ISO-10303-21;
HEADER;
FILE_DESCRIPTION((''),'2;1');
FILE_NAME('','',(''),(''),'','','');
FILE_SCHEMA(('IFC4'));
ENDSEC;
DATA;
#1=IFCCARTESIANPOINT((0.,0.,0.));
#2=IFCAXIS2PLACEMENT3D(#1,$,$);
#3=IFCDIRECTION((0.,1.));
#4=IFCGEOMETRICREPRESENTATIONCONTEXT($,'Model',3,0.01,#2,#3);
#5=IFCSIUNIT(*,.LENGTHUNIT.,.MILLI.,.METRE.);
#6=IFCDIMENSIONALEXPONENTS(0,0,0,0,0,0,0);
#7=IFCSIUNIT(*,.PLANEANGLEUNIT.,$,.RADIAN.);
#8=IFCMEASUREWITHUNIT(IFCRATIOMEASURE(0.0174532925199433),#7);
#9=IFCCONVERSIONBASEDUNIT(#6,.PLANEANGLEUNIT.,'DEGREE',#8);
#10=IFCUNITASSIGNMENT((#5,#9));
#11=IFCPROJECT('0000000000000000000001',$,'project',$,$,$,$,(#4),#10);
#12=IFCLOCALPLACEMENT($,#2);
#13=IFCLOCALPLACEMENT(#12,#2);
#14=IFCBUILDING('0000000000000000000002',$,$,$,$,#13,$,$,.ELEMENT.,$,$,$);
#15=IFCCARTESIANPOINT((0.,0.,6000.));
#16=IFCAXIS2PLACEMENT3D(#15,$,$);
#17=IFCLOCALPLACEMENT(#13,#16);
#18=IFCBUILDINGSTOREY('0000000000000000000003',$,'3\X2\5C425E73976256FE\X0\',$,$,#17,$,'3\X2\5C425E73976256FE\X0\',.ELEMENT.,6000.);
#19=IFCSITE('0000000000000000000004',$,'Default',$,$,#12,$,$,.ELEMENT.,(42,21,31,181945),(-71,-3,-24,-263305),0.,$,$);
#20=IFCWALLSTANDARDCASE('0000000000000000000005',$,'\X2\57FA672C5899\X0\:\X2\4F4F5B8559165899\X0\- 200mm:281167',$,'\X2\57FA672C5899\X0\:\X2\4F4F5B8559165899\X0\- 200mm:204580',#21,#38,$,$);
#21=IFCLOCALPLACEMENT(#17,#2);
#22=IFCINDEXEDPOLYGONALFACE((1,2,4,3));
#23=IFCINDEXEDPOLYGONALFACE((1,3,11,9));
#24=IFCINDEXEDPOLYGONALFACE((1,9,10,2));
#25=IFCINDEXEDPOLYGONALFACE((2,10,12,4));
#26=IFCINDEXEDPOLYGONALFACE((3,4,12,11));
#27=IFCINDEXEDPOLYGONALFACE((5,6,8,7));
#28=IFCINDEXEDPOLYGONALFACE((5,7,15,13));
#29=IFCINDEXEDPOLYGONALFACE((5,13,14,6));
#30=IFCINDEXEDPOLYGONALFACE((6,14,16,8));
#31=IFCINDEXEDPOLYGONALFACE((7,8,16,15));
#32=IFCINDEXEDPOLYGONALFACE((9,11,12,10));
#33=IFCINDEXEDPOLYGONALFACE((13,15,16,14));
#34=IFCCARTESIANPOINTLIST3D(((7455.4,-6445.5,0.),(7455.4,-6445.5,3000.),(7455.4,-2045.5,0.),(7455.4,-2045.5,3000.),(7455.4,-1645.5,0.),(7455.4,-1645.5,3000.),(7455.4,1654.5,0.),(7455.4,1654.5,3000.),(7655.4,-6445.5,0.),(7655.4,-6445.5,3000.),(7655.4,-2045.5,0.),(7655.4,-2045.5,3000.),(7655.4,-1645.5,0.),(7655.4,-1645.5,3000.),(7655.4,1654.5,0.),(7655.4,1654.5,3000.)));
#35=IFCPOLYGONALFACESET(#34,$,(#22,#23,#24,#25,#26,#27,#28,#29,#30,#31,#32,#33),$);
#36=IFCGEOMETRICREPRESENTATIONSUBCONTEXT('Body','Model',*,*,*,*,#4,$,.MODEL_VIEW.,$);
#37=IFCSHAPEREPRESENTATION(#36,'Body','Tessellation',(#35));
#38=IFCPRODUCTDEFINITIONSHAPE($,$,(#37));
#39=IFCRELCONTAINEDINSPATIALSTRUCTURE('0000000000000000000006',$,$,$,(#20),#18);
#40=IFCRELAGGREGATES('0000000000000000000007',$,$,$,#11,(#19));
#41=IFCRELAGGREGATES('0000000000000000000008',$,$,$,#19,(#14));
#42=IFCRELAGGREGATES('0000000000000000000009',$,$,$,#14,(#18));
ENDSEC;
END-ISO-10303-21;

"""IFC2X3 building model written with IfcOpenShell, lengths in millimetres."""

from ifc_helpers import new_model, entity, si_unit, converted_unit, direction, frame, frame_2d, origin, origin_2d_with_axis, place, context, subcontext, project, spatial, polyline, rectangle, extrude, clip, bounded_halfspace, element, save


model = new_model("IFC2X3")

# Units and contexts
model_context = context("Model", 3, precision=0.01, world=origin(), true_north=direction((0.0, 1.0)))
body_context = subcontext(model_context, "Body", "Model", "MODEL_VIEW")
ifc_project = project(units=[si_unit("LENGTHUNIT", "METRE", prefix="MILLI"), converted_unit("PLANEANGLEUNIT", "DEGREE", entity("IfcRatioMeasure", 0.0174532925199433), si_unit("PLANEANGLEUNIT", "RADIAN"), dimensions=[0, 0, 0, 0, 0, 0, 0])], contexts=[model_context])

# Site, building, storey
site_placement = place(None, origin())
site = spatial("IfcSite", under=ifc_project, at=site_placement, Name="Default", CompositionType="ELEMENT", RefLatitude=(42, 21, 31, 181945), RefLongitude=(-71, -3, -24, -263305), RefElevation=0.0)
building_placement = place(site_placement, origin())
building = spatial("IfcBuilding", under=site, at=building_placement, CompositionType="ELEMENT")
storey_placement = place(building_placement, frame((0.0, 0.0, 6000.0)))
storey = spatial("IfcBuildingStorey", under=building, at=storey_placement, Name="3层平面图", LongName="3层平面图", CompositionType="ELEMENT", Elevation=6000.0)

# Wall, opening
wall_placement = place(storey_placement, frame((7555.4, 1654.5, 0.0), z_axis=(0.0, 0.0, 1.0), x_axis=(0.0, -1.0, 0.0)))
wall = element("IfcWallStandardCase", 1, at=wall_placement, inside=storey, Name="基本墙:住宅外墙- 200mm:281167", ObjectType="基本墙:住宅外墙- 200mm:204580", context=body_context, shape_type="Clipping", body=[
    clip(extrude(rectangle(XDim=8100.0, YDim=200.0, at=frame_2d((4050.0, 0.0), x_axis=(-1.0, 0.0))), origin(), (0.0, 0.0, 1.0), 3000.0), bounded_halfspace(frame((8100.0, -100.0, 3000.0), z_axis=(1.0, 0.0, 0.0), x_axis=(0.0, 0.0, -1.0)), False, frame((8100.0, -100.0, 3000.0), z_axis=(1.0, 0.0, 0.0), x_axis=(0.0, 0.0, -1.0)), polyline([(0.0, 0.0), (3000.0, 0.0), (3000.0, 200.0), (0.0, 200.0), (0.0, 0.0)]))),
])
opening_placement = place(storey_placement, frame((7555.4, 1654.5, 0.0), z_axis=(0.0, 0.0, 1.0), x_axis=(0.0, -1.0, 0.0)))
element("IfcOpeningElement", 2, at=opening_placement, cuts=wall, ObjectType="Opening", context=body_context, shape_type="SweptSolid", body=[
    extrude(rectangle(XDim=3000.0, YDim=200.0, at=origin_2d_with_axis()), frame((3700.0, 0.0, 1500.0), z_axis=(-1.0, 0.0, 0.0), x_axis=(0.0, 0.0, 1.0)), (0.0, 0.0, 1.0), 400.0),
])

save(model, "model.ifc")
